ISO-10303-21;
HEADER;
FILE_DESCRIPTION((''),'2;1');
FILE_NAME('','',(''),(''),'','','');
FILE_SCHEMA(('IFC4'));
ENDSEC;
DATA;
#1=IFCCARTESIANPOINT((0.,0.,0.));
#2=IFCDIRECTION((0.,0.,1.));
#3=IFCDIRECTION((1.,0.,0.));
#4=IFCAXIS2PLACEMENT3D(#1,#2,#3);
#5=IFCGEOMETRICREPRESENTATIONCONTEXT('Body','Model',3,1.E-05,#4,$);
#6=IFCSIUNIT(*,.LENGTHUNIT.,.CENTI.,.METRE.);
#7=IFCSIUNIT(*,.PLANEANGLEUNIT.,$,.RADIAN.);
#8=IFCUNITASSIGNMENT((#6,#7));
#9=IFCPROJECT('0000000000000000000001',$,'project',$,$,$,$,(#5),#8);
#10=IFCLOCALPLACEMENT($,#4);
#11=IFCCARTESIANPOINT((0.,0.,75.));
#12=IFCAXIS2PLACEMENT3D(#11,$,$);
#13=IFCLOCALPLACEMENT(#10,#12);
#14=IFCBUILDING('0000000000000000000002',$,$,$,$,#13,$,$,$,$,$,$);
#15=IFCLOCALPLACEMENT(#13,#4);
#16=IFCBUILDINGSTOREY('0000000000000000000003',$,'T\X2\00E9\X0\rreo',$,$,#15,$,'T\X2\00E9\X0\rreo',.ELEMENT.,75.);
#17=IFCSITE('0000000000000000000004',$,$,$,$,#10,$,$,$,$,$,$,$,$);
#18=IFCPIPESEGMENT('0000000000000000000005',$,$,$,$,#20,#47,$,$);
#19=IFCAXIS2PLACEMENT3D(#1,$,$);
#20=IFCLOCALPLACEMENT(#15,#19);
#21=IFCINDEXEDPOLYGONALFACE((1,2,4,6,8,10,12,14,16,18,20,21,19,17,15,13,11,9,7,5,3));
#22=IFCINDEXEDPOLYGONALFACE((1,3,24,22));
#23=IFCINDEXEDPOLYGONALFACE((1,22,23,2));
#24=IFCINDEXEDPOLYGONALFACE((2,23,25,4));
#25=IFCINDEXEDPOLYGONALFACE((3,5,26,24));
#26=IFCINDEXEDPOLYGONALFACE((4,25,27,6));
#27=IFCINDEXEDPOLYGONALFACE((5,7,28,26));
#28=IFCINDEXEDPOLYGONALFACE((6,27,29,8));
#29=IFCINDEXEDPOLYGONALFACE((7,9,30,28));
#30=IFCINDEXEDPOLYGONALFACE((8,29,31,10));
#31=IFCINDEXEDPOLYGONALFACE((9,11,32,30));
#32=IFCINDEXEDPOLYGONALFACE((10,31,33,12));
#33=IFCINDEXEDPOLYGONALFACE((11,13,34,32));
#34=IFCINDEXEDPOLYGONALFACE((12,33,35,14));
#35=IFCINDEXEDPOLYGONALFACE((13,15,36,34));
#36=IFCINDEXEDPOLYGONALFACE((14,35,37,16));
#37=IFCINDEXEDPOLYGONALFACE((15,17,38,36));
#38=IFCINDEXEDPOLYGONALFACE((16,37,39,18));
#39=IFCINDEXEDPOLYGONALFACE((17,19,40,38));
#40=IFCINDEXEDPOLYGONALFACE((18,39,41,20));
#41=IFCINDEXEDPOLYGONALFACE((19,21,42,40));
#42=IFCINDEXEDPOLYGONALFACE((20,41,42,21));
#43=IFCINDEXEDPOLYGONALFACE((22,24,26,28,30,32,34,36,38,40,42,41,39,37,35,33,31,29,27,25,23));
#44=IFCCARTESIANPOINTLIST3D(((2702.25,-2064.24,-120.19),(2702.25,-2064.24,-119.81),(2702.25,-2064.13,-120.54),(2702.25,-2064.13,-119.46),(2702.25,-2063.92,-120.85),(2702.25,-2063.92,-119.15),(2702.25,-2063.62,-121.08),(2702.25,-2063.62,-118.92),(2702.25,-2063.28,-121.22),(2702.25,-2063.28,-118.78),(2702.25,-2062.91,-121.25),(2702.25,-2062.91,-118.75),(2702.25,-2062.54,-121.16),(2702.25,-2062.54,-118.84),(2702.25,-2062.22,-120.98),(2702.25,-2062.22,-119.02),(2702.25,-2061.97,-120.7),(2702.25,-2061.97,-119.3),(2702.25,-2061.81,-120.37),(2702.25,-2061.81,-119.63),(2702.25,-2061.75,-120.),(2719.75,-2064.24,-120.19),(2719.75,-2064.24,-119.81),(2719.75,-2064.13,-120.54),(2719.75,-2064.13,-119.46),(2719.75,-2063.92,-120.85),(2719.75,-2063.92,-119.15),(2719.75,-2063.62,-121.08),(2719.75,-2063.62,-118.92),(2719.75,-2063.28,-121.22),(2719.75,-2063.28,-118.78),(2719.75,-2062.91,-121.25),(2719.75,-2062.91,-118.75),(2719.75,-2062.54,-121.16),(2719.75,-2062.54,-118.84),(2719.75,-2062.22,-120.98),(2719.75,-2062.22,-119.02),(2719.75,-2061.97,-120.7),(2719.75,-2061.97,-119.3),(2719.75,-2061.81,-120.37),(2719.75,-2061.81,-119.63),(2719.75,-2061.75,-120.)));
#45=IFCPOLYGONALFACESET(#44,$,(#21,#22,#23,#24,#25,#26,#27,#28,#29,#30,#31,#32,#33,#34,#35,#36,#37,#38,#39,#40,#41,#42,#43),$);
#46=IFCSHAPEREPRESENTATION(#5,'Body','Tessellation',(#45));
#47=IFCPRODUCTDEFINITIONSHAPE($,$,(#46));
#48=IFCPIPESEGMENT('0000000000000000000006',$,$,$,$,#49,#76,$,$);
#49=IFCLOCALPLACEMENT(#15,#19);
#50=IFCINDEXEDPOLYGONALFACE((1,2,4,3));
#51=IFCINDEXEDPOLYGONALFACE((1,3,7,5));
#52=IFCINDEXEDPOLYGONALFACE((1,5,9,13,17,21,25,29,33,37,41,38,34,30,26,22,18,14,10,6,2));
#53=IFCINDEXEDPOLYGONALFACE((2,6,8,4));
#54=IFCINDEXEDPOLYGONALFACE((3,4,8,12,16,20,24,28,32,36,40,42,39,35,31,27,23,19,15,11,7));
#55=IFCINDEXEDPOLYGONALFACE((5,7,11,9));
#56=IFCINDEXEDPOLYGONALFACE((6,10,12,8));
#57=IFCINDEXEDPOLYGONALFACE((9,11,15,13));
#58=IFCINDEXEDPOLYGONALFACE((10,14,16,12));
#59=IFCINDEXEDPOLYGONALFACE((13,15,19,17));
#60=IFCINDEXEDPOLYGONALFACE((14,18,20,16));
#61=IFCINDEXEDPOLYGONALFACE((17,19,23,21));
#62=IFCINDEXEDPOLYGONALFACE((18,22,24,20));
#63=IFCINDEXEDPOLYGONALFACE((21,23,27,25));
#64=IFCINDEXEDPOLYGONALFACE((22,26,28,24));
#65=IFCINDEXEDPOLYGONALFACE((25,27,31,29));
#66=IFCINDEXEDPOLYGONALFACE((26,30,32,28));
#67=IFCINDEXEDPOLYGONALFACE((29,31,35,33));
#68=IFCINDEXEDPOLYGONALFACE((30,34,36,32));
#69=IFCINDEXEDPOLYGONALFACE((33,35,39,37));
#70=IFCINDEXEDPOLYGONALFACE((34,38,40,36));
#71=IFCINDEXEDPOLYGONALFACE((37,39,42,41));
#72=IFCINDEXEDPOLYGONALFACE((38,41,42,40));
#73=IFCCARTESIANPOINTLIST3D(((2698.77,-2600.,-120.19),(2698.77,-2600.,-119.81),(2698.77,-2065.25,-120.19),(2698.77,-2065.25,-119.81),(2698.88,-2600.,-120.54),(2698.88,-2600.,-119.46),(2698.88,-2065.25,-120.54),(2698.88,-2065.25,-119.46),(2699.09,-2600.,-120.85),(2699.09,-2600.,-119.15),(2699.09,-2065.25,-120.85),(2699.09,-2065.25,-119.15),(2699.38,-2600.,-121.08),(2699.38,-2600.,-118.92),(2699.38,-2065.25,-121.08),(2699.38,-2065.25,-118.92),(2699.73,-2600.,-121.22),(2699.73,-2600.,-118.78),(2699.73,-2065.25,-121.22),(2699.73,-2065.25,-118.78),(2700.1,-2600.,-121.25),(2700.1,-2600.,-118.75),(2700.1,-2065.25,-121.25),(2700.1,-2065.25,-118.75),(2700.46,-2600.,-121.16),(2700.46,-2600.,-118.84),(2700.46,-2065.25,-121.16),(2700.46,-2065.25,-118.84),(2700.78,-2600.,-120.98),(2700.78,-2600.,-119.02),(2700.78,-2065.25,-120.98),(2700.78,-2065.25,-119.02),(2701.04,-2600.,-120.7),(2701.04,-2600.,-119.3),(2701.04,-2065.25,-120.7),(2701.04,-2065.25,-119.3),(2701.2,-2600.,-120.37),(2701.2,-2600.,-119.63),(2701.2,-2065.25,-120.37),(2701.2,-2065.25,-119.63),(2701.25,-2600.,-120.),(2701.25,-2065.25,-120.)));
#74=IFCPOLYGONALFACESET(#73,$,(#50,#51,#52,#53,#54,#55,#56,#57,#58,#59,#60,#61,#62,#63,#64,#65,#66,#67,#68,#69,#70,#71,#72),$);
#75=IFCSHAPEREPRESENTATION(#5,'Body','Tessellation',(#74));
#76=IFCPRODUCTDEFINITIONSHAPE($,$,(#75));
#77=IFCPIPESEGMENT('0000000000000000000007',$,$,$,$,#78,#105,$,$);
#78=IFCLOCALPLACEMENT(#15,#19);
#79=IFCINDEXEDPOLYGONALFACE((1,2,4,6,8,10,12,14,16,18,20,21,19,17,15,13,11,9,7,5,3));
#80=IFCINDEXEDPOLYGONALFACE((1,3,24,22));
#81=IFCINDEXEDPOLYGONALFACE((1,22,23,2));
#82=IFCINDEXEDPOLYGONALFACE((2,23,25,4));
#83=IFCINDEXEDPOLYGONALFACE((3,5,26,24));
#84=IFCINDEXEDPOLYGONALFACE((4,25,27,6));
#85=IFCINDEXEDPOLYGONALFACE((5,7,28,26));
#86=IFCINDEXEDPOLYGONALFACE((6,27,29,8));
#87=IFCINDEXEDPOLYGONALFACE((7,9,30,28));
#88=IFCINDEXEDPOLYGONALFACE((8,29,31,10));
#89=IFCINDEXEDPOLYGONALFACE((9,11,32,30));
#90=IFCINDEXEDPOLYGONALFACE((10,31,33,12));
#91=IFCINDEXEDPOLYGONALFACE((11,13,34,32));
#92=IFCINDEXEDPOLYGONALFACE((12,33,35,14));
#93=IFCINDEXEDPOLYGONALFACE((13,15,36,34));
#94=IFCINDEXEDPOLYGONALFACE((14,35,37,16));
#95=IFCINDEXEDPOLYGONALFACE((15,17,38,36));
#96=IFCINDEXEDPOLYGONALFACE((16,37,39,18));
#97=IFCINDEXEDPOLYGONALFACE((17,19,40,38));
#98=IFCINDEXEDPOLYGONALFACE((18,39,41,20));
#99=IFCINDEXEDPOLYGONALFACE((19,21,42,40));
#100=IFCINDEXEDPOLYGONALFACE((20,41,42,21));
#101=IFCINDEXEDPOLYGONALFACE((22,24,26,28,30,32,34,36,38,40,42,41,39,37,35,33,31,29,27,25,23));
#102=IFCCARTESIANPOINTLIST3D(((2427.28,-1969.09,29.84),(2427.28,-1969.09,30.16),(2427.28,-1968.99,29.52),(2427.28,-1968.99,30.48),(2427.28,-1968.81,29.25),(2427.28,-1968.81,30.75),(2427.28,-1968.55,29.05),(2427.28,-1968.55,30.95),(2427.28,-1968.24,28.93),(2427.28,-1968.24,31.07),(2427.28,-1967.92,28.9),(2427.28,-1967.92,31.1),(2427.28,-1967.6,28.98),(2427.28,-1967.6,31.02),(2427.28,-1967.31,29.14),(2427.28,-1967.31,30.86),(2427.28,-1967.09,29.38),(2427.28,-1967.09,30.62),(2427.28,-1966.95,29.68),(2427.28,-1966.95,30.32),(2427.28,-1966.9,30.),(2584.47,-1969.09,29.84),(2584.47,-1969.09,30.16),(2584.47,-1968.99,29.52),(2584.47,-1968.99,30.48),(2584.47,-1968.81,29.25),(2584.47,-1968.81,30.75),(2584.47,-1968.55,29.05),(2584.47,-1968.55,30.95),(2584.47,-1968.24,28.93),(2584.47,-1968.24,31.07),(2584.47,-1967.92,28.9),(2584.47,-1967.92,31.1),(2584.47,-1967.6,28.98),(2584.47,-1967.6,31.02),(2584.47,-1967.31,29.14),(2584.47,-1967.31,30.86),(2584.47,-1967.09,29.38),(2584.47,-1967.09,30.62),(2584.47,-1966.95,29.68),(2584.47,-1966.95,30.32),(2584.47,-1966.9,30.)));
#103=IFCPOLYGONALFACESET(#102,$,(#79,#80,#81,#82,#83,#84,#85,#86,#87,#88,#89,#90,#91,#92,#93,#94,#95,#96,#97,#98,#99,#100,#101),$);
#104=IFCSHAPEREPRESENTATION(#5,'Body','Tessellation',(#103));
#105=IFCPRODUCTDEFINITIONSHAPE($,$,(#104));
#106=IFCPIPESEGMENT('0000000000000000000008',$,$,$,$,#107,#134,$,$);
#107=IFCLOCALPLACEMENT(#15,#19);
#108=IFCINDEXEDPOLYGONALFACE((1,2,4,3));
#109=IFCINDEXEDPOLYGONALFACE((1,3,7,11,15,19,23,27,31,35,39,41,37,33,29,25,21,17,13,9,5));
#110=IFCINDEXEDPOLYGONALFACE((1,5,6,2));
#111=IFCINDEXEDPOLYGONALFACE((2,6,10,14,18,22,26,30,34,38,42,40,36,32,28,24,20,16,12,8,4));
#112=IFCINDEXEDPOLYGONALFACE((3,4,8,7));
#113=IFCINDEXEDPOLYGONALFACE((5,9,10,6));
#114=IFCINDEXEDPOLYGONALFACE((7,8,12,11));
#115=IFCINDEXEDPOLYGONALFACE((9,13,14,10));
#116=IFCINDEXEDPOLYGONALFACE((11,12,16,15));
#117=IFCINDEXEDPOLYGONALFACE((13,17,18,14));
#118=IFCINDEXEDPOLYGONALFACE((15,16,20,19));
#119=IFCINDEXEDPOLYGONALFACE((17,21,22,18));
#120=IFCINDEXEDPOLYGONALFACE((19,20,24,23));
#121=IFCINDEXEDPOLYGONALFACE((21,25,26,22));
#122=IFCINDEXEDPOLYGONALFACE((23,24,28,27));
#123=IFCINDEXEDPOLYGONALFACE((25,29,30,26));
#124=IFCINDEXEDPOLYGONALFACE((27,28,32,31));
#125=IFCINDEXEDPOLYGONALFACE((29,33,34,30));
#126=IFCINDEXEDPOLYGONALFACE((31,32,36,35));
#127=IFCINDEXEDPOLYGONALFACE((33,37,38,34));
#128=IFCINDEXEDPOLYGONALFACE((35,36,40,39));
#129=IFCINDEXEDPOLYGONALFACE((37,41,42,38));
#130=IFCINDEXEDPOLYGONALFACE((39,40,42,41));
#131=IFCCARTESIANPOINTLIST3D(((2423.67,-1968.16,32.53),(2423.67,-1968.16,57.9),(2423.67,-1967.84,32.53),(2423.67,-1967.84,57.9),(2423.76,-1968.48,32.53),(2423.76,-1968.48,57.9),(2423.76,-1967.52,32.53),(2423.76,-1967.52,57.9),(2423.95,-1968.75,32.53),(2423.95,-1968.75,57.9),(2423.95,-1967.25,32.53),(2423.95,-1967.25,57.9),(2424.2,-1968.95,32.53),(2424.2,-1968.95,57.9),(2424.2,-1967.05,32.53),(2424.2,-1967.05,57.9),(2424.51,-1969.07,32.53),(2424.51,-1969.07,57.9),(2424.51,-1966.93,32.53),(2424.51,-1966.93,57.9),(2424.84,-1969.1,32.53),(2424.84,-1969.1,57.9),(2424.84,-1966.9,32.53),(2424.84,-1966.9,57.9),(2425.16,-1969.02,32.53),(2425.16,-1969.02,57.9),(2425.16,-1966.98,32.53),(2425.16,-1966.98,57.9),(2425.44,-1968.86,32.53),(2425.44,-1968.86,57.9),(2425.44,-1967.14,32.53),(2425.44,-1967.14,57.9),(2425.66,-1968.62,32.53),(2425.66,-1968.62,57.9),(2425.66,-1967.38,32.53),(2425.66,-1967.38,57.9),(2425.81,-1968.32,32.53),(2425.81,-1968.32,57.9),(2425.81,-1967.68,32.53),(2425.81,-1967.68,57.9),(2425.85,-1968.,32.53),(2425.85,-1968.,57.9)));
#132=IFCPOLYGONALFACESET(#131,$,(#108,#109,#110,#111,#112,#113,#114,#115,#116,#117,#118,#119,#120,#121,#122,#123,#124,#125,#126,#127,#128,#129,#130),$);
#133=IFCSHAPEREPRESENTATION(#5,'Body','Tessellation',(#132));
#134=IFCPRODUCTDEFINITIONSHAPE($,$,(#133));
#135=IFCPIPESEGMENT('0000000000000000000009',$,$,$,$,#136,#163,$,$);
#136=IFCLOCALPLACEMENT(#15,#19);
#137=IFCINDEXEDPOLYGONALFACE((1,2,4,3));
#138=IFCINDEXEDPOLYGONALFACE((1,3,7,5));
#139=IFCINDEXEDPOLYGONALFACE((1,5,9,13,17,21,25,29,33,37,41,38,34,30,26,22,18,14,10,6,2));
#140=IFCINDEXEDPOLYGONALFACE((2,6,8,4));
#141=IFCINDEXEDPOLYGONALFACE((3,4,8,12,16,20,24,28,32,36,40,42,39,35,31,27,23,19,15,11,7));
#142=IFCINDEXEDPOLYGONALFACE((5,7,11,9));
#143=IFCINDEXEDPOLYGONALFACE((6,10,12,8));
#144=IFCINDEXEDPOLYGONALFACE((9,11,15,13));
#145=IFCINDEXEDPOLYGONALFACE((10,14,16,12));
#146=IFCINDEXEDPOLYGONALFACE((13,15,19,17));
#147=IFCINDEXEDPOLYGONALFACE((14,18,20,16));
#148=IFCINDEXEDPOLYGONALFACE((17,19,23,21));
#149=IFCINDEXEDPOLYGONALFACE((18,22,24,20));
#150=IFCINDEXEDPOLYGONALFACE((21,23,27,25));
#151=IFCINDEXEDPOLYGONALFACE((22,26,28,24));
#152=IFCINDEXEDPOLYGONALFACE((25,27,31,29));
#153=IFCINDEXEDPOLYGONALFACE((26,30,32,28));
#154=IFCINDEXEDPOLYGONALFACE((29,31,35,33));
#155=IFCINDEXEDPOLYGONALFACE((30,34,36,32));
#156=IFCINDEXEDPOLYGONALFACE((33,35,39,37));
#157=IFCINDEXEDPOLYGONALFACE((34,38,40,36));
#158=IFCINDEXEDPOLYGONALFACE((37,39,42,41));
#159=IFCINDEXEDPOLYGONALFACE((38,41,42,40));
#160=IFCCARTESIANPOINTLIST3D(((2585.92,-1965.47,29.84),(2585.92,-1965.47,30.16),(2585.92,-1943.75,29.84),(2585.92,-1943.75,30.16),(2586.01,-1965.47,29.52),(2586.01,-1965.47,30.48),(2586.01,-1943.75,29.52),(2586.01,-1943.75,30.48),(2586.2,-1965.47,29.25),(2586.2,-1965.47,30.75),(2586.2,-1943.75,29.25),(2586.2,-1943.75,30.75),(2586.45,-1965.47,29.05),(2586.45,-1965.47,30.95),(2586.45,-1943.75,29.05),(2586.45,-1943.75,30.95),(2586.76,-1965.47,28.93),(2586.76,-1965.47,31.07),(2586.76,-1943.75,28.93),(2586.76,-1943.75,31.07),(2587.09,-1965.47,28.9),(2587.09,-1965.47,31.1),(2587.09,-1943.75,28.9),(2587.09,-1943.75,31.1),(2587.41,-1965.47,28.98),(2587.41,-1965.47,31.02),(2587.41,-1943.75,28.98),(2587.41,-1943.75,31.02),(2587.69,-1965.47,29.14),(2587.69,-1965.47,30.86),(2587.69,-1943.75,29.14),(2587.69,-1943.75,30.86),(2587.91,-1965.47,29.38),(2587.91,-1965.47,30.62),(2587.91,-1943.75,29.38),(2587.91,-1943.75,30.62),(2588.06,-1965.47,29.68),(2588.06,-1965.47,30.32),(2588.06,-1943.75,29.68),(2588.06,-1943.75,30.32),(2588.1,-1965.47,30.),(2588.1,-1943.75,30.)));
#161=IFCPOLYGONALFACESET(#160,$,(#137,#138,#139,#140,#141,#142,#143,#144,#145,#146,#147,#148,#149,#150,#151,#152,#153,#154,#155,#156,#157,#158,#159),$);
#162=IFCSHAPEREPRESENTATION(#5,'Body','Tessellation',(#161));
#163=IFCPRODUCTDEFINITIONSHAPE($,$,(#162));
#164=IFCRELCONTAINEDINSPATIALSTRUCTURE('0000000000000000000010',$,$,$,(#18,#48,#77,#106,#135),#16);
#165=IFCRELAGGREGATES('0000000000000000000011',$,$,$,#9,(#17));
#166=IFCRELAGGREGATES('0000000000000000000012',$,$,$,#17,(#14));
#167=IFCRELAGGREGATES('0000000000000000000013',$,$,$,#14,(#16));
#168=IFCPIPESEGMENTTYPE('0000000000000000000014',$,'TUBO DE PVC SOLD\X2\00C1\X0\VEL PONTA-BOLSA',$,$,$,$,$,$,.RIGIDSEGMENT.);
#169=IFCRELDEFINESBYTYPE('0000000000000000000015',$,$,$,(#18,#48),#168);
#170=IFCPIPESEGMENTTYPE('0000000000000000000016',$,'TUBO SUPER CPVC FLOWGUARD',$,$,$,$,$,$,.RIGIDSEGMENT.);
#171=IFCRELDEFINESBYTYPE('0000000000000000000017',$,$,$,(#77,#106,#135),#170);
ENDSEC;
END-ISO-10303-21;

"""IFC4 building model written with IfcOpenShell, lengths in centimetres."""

from ifc_helpers import new_model, si_unit, frame, origin_with_axes, origin_2d_with_axis, place, context, project, spatial, circle, extrude, type_object, element, save


model = new_model("IFC4")

# Units and contexts
model_context = context("Model", 3, precision=1e-05, world=origin_with_axes(), identifier="Body")
ifc_project = project(units=[si_unit("LENGTHUNIT", "METRE", prefix="CENTI"), si_unit("PLANEANGLEUNIT", "RADIAN")], contexts=[model_context])

# Site, building, storey
site_placement = place(None, origin_with_axes())
site = spatial("IfcSite", under=ifc_project, at=site_placement)
building_placement = place(site_placement, frame((0.0, 0.0, 75.0)))
building = spatial("IfcBuilding", under=site, at=building_placement)
storey_placement = place(building_placement, origin_with_axes())
storey = spatial("IfcBuildingStorey", under=building, at=storey_placement, Name="Térreo", LongName="Térreo", CompositionType="ELEMENT", Elevation=75.0)

# Pipe segments
pipe_segment_type_1 = type_object("IfcPipeSegmentType", Name="TUBO DE PVC SOLDÁVEL PONTA-BOLSA", PredefinedType="RIGIDSEGMENT")
pipe_segment_1_placement = place(storey_placement, frame((2711.0, -2063.0, -118.75), z_axis=(0.0, 0.0, 1.0), x_axis=(1.0, 0.0, 0.0)))
element("IfcPipeSegment", 1, at=pipe_segment_1_placement, inside=storey, type_object=pipe_segment_type_1, context=model_context, shape_type="SolidModel", body=[
    extrude(circle(Radius=1.25, at=origin_2d_with_axis()), frame((-8.75, 0.0, -1.25), z_axis=(1.0, 0.0, 0.0), x_axis=(0.0, 1.0, 0.0)), (0.0, 0.0, 1.0), 17.5),
])
pipe_segment_2_placement = place(storey_placement, frame((2700.0, -2332.62, -118.75), z_axis=(0.0, 0.0, 1.0), x_axis=(1.0, 0.0, 0.0)))
element("IfcPipeSegment", 2, at=pipe_segment_2_placement, inside=storey, type_object=pipe_segment_type_1, context=model_context, shape_type="SolidModel", body=[
    extrude(circle(Radius=1.25, at=origin_2d_with_axis()), frame((0.0, -267.37, -1.25), z_axis=(0.0, 1.0, 0.0), x_axis=(1.0, 0.0, 0.0)), (0.0, 0.0, 1.0), 534.75),
])
pipe_segment_type_2 = type_object("IfcPipeSegmentType", Name="TUBO SUPER CPVC FLOWGUARD", PredefinedType="RIGIDSEGMENT")
pipe_segment_3_placement = place(storey_placement, frame((2505.88, -1968.0, 31.1), z_axis=(0.0, 0.0, 1.0), x_axis=(1.0, 0.0, 0.0)))
element("IfcPipeSegment", 3, at=pipe_segment_3_placement, inside=storey, type_object=pipe_segment_type_2, context=model_context, shape_type="SolidModel", body=[
    extrude(circle(Radius=1.1, at=origin_2d_with_axis()), frame((78.59, 0.0, -1.1), z_axis=(-1.0, 0.0, 0.0), x_axis=(0.0, 1.0, 0.0)), (0.0, 0.0, 1.0), 157.19),
])
pipe_segment_4_placement = place(storey_placement, frame((2424.75, -1968.0, 57.9), z_axis=(0.0, 0.0, 1.0), x_axis=(1.0, 0.0, 0.0)))
element("IfcPipeSegment", 4, at=pipe_segment_4_placement, inside=storey, type_object=pipe_segment_type_2, context=model_context, shape_type="SolidModel", body=[
    extrude(circle(Radius=1.1, at=origin_2d_with_axis()), frame((0.0, 0.0, -25.37), z_axis=(0.0, 0.0, 1.0), x_axis=(1.0, 0.0, 0.0)), (0.0, 0.0, 1.0), 25.37),
])
pipe_segment_5_placement = place(storey_placement, frame((2587.0, -1954.61, 31.1), z_axis=(0.0, 0.0, 1.0), x_axis=(1.0, 0.0, 0.0)))
element("IfcPipeSegment", 5, at=pipe_segment_5_placement, inside=storey, type_object=pipe_segment_type_2, context=model_context, shape_type="SolidModel", body=[
    extrude(circle(Radius=1.1, at=origin_2d_with_axis()), frame((0.0, 10.86, -1.1), z_axis=(0.0, -1.0, 0.0), x_axis=(1.0, 0.0, 0.0)), (0.0, 0.0, 1.0), 21.72),
])

save(model, "model.ifc")
